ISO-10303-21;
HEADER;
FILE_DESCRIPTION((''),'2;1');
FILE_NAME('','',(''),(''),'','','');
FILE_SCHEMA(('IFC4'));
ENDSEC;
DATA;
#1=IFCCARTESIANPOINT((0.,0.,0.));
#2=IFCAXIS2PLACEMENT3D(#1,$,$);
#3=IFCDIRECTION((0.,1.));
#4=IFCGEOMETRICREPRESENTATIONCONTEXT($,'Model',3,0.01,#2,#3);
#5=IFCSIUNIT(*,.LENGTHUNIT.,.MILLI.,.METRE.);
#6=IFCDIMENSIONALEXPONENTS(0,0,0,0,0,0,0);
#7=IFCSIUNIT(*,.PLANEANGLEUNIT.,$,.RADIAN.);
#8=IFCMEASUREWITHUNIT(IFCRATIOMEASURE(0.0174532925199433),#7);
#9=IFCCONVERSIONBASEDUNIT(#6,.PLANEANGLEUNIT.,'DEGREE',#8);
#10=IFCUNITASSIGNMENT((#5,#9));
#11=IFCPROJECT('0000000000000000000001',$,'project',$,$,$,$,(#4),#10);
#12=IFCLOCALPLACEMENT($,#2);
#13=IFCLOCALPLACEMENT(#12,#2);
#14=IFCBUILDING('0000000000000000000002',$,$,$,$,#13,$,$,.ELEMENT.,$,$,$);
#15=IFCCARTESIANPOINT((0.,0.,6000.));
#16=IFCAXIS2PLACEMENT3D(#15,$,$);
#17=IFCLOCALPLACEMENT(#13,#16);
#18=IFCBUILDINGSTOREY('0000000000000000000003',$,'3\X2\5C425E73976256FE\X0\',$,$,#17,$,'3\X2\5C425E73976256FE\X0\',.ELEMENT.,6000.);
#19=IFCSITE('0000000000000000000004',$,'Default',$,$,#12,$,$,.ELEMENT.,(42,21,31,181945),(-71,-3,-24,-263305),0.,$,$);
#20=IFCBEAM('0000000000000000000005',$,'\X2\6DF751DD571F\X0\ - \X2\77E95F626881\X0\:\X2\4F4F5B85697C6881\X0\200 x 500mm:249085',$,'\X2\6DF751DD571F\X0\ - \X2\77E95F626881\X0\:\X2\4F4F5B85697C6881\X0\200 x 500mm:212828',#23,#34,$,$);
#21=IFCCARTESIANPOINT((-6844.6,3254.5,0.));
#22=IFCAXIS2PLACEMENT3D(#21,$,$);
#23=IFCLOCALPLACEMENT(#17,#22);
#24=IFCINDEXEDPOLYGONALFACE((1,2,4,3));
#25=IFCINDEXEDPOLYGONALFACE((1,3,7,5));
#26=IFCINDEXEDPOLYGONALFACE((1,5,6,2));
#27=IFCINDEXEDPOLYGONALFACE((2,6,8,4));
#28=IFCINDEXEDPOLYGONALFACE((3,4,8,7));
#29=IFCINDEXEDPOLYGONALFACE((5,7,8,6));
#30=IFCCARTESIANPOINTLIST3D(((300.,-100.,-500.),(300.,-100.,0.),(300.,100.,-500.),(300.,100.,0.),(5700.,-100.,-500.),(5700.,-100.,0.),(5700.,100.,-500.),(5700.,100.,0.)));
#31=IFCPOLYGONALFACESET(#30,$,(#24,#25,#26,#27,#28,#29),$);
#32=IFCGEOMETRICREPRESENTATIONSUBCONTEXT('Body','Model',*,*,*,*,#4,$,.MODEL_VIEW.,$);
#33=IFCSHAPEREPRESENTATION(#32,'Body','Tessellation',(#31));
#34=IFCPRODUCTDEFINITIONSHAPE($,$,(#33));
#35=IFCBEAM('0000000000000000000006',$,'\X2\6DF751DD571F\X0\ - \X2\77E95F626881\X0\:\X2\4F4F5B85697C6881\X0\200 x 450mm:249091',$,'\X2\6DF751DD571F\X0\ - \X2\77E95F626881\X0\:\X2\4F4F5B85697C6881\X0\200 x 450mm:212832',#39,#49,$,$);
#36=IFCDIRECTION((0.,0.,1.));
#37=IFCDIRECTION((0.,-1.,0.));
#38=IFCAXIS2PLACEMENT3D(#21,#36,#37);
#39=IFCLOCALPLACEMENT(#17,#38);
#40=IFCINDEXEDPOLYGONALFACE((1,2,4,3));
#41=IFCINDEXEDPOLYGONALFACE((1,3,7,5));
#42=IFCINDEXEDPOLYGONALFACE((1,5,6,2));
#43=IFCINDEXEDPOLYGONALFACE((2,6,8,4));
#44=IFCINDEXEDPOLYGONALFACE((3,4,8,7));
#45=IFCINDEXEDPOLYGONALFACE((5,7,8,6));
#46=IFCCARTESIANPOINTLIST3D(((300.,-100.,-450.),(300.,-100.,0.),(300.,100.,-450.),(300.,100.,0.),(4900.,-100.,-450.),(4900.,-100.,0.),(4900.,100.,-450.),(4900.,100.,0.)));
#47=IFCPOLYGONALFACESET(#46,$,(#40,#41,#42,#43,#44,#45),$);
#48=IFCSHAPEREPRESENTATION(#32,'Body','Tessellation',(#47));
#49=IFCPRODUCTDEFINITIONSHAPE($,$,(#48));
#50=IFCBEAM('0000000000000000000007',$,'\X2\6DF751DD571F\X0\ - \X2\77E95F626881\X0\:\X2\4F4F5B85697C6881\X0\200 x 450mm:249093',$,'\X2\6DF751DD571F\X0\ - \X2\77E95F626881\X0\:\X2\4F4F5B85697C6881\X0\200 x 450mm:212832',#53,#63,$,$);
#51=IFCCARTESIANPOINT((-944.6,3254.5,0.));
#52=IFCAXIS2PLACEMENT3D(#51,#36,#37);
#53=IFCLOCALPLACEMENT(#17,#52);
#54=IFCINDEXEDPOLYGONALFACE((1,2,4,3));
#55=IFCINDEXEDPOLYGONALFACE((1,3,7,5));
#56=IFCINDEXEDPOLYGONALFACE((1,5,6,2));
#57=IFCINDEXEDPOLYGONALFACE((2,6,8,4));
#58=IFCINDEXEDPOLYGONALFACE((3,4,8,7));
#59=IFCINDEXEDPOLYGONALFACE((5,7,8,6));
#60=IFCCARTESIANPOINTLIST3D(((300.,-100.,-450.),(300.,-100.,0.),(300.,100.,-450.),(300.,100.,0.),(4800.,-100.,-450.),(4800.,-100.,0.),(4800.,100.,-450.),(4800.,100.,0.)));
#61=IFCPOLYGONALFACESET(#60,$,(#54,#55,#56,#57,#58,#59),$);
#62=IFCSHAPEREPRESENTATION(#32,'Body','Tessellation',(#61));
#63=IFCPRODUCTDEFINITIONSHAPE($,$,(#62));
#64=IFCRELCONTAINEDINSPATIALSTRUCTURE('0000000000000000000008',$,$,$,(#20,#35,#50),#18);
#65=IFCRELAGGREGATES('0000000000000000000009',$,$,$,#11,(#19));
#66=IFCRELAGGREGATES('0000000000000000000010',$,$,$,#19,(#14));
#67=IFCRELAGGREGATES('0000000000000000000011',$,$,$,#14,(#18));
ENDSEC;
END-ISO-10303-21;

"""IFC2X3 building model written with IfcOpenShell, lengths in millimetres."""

from ifc_helpers import new_model, entity, si_unit, converted_unit, direction, frame, frame_2d, origin, place, context, subcontext, project, spatial, rectangle, extrude, element, save


model = new_model("IFC2X3")

# Units and contexts
model_context = context("Model", 3, precision=0.01, world=origin(), true_north=direction((0.0, 1.0)))
body_context = subcontext(model_context, "Body", "Model", "MODEL_VIEW")
ifc_project = project(units=[si_unit("LENGTHUNIT", "METRE", prefix="MILLI"), converted_unit("PLANEANGLEUNIT", "DEGREE", entity("IfcRatioMeasure", 0.0174532925199433), si_unit("PLANEANGLEUNIT", "RADIAN"), dimensions=[0, 0, 0, 0, 0, 0, 0])], contexts=[model_context])

# Site, building, storey
site_placement = place(None, origin())
site = spatial("IfcSite", under=ifc_project, at=site_placement, Name="Default", CompositionType="ELEMENT", RefLatitude=(42, 21, 31, 181945), RefLongitude=(-71, -3, -24, -263305), RefElevation=0.0)
building_placement = place(site_placement, origin())
building = spatial("IfcBuilding", under=site, at=building_placement, CompositionType="ELEMENT")
storey_placement = place(building_placement, frame((0.0, 0.0, 6000.0)))
storey = spatial("IfcBuildingStorey", under=building, at=storey_placement, Name="3层平面图", LongName="3层平面图", CompositionType="ELEMENT", Elevation=6000.0)

# Beams
beam_1_placement = place(storey_placement, frame((-6844.6, 3254.5, 0.0)))
element("IfcBeam", 1, at=beam_1_placement, inside=storey, Name="混凝土 - 矩形梁:住宅楼梁200 x 500mm:249085", ObjectType="混凝土 - 矩形梁:住宅楼梁200 x 500mm:212828", context=body_context, shape_type="SweptSolid", body=[
    extrude(rectangle(XDim=500.0, YDim=200.0, at=frame_2d((0.0, 0.0), x_axis=(1.0, 0.0))), frame((300.0, 0.0, -250.0), z_axis=(1.0, 0.0, 0.0), x_axis=(0.0, 0.0, -1.0)), (0.0, 0.0, 1.0), 5400.0),
])
beam_2_placement = place(storey_placement, frame((-6844.6, 3254.5, 0.0), z_axis=(0.0, 0.0, 1.0), x_axis=(0.0, -1.0, 0.0)))
element("IfcBeam", 2, at=beam_2_placement, inside=storey, Name="混凝土 - 矩形梁:住宅楼梁200 x 450mm:249091", ObjectType="混凝土 - 矩形梁:住宅楼梁200 x 450mm:212832", context=body_context, shape_type="SweptSolid", body=[
    extrude(rectangle(XDim=450.0, YDim=200.0, at=frame_2d((0.0, 0.0), x_axis=(1.0, 0.0))), frame((300.0, 0.0, -225.0), z_axis=(1.0, 0.0, 0.0), x_axis=(0.0, 0.0, -1.0)), (0.0, 0.0, 1.0), 4600.0),
])
beam_3_placement = place(storey_placement, frame((-944.6, 3254.5, 0.0), z_axis=(0.0, 0.0, 1.0), x_axis=(0.0, -1.0, 0.0)))
element("IfcBeam", 3, at=beam_3_placement, inside=storey, Name="混凝土 - 矩形梁:住宅楼梁200 x 450mm:249093", ObjectType="混凝土 - 矩形梁:住宅楼梁200 x 450mm:212832", context=body_context, shape_type="SweptSolid", body=[
    extrude(rectangle(XDim=450.0, YDim=200.0, at=frame_2d((0.0, 0.0), x_axis=(1.0, 0.0))), frame((300.0, 0.0, -225.0), z_axis=(1.0, 0.0, 0.0), x_axis=(0.0, 0.0, -1.0)), (0.0, 0.0, 1.0), 4500.0),
])

save(model, "model.ifc")
